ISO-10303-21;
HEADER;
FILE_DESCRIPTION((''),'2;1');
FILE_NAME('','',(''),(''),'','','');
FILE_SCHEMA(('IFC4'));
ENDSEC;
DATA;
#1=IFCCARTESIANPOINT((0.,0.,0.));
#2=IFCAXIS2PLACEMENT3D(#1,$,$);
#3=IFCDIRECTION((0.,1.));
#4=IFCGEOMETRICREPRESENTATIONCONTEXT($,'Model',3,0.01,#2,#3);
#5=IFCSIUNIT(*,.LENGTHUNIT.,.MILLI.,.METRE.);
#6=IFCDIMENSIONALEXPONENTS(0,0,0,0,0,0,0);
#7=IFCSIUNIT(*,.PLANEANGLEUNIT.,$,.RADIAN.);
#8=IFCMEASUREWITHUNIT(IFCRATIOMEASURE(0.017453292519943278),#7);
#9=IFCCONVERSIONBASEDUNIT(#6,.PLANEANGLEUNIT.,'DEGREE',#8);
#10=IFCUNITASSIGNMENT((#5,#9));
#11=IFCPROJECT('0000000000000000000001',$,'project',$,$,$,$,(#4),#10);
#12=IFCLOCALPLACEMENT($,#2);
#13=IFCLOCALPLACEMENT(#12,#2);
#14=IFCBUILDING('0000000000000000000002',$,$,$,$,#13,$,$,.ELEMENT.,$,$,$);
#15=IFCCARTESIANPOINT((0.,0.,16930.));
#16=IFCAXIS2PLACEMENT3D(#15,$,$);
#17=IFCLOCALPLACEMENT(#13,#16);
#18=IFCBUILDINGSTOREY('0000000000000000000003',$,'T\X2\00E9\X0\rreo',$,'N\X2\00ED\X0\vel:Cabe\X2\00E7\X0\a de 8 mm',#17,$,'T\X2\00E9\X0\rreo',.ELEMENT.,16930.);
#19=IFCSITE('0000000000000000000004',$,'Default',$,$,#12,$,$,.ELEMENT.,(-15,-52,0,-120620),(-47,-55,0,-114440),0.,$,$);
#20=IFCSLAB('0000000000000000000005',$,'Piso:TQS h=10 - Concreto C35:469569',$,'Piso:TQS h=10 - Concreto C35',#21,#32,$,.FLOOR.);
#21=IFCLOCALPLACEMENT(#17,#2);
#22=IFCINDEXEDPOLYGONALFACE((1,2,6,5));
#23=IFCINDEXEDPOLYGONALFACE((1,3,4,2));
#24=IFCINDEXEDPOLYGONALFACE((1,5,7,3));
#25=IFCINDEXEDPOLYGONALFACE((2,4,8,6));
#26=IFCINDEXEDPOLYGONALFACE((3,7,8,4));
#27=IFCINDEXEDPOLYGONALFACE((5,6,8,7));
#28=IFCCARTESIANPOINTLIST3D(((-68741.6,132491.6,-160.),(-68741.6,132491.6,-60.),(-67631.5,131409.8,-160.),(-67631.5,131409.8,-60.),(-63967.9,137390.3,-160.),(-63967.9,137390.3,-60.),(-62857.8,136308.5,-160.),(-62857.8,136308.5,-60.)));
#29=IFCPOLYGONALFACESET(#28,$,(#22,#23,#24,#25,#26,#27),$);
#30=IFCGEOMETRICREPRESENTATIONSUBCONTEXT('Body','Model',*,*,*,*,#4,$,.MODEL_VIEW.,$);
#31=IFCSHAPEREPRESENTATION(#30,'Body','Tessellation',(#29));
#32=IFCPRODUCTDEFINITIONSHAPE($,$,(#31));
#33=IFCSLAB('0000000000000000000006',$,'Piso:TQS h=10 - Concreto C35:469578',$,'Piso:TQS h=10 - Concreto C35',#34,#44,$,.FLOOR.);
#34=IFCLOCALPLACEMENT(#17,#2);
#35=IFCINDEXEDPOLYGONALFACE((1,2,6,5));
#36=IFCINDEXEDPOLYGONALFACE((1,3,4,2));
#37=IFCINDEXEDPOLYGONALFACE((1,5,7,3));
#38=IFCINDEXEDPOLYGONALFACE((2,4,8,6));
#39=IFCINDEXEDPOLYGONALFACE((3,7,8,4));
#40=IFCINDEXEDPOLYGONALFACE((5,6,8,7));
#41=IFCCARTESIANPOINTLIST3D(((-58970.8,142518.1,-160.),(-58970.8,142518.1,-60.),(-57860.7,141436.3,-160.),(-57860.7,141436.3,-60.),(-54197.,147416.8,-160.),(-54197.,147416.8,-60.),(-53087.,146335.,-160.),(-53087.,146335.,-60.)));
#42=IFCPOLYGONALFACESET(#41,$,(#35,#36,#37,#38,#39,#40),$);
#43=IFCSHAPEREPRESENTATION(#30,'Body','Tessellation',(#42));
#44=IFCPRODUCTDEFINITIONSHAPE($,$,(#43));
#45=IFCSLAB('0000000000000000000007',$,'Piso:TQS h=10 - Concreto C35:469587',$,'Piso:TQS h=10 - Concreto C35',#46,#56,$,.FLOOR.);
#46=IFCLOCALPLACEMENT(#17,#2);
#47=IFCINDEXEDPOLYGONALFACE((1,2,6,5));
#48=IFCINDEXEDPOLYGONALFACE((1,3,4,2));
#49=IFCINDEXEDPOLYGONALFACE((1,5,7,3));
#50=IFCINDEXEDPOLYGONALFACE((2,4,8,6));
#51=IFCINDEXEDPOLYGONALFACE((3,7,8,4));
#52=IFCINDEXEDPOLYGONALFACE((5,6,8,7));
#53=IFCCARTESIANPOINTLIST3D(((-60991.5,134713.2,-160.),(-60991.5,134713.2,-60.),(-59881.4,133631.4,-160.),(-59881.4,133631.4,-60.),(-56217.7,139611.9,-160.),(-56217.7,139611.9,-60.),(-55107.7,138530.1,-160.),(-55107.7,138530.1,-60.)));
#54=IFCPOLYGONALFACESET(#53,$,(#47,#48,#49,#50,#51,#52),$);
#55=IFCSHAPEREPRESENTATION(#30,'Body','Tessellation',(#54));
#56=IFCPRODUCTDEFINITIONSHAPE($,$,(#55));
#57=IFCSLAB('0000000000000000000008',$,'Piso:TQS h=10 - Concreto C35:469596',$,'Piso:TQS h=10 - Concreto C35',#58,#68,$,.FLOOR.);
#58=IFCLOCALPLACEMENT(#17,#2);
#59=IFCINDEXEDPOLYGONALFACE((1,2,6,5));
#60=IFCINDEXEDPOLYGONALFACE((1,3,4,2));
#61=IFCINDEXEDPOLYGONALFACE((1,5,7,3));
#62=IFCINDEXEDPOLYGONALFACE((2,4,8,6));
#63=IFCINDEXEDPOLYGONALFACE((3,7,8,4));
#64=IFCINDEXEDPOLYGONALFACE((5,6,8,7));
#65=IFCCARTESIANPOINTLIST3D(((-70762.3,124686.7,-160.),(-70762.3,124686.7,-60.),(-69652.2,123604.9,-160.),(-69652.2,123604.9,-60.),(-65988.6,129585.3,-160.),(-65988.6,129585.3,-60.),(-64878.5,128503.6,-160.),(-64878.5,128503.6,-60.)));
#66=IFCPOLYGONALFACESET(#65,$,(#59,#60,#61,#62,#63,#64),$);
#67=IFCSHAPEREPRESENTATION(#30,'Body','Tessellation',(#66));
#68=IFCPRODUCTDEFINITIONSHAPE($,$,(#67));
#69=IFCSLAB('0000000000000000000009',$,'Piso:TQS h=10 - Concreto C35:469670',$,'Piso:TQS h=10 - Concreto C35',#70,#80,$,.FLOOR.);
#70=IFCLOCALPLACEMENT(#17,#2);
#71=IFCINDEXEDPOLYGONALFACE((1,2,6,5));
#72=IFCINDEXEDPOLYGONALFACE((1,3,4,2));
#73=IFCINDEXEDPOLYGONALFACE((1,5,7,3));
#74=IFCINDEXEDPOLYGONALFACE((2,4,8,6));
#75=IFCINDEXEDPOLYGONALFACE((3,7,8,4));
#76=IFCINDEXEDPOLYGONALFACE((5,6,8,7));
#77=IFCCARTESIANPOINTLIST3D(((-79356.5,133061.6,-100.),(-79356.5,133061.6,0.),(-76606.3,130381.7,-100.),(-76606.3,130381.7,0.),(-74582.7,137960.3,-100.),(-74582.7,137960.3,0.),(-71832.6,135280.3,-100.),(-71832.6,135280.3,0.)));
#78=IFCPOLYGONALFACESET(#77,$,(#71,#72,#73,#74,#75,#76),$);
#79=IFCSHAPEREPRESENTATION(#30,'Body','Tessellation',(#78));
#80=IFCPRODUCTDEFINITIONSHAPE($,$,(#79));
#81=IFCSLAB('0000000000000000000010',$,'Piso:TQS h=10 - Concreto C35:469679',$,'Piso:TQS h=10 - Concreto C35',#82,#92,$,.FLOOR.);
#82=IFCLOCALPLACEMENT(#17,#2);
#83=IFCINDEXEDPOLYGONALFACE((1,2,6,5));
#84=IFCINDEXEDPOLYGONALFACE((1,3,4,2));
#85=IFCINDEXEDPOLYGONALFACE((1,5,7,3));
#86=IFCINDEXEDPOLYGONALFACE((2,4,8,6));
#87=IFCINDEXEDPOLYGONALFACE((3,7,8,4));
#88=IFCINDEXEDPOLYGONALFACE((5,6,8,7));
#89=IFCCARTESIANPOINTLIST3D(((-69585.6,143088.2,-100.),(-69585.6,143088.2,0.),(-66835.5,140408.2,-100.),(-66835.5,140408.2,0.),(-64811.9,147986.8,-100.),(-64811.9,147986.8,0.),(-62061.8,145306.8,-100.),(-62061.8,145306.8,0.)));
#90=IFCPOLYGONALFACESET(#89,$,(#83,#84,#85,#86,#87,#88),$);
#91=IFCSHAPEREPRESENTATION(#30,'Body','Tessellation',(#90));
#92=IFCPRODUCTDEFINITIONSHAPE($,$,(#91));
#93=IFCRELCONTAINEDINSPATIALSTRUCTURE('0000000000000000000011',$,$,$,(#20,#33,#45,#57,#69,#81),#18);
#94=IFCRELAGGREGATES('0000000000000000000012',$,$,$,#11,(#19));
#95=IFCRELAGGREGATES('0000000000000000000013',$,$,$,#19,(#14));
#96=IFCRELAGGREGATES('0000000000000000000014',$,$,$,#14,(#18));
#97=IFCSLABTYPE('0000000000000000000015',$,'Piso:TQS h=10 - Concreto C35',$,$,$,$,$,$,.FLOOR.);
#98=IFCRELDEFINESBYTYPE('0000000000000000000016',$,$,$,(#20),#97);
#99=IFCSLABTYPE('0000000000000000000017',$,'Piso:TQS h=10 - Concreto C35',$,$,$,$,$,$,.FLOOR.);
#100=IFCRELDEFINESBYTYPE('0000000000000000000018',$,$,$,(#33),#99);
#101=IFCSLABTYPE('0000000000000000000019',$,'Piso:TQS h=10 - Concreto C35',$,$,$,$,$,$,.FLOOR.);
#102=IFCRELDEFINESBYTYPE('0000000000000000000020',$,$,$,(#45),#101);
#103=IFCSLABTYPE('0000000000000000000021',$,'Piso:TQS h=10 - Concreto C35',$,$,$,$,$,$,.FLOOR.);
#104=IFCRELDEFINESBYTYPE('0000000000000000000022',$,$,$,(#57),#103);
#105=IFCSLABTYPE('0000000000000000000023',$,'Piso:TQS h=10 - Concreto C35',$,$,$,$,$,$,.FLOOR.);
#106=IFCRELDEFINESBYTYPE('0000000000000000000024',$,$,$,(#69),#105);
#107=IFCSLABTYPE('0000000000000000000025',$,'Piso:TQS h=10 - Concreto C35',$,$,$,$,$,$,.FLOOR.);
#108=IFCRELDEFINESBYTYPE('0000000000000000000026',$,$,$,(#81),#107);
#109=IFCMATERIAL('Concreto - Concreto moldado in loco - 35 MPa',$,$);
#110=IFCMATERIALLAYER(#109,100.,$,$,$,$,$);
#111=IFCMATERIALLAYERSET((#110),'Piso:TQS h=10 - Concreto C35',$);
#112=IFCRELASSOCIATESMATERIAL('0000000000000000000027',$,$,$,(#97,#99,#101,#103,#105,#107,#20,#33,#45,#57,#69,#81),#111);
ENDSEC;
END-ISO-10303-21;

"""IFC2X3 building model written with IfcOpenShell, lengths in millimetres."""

from ifc_helpers import new_model, entity, si_unit, converted_unit, direction, frame, frame_2d, origin, origin_2d_with_axis, place, context, subcontext, project, spatial, rectangle, extrude, material, layer, layer_set, layer_usage, type_object, element, save


model = new_model("IFC2X3")

# Units and contexts
model_context = context("Model", 3, precision=0.01, world=origin(), true_north=direction((0.0, 1.0)))
body_context = subcontext(model_context, "Body", "Model", "MODEL_VIEW")
ifc_project = project(units=[si_unit("LENGTHUNIT", "METRE", prefix="MILLI"), converted_unit("PLANEANGLEUNIT", "DEGREE", entity("IfcRatioMeasure", 0.017453292519943278), si_unit("PLANEANGLEUNIT", "RADIAN"), dimensions=[0, 0, 0, 0, 0, 0, 0])], contexts=[model_context])

# Site, building, storey
site_placement = place(None, origin())
site = spatial("IfcSite", under=ifc_project, at=site_placement, Name="Default", CompositionType="ELEMENT", RefLatitude=(-15, -52, 0, -120620), RefLongitude=(-47, -55, 0, -114440), RefElevation=0.0)
building_placement = place(site_placement, origin())
building = spatial("IfcBuilding", under=site, at=building_placement, CompositionType="ELEMENT")
storey_placement = place(building_placement, frame((0.0, 0.0, 16930.0)))
storey = spatial("IfcBuildingStorey", under=building, at=storey_placement, Name="Térreo", ObjectType="Nível:Cabeça de 8 mm", LongName="Térreo", CompositionType="ELEMENT", Elevation=16930.0)

# Shared definitions
ifc_material = material(Name="Concreto - Concreto moldado in loco - 35 MPa")

# Slabs
ifc_layer = layer(ifc_material, 100.0)
ifc_layer_set = layer_set([ifc_layer], Name="Piso:TQS h=10 - Concreto C35")
ifc_layer_usage_1 = layer_usage(ifc_layer_set, "AXIS3", "POSITIVE", 0.0)
slab_type_1 = type_object("IfcSlabType", Name="Piso:TQS h=10 - Concreto C35", PredefinedType="FLOOR", material=ifc_layer_set)
slab_1_placement = place(storey_placement, origin())
element("IfcSlab", 1, at=slab_1_placement, inside=storey, type_object=slab_type_1, material=ifc_layer_usage_1, Name="Piso:TQS h=10 - Concreto C35:469569", ObjectType="Piso:TQS h=10 - Concreto C35", PredefinedType="FLOOR", context=body_context, shape_type="SweptSolid", body=[
    extrude(rectangle(XDim=6840.0, YDim=1550.0, at=frame_2d((0.0, 0.0), x_axis=(1.0, 0.0))), frame((-65799.7, 134400.0, -60.0), z_axis=(0.0, 0.0, -1.0), x_axis=(-0.697915, -0.71618, 0.0)), (0.0, 0.0, 1.0), 100.0),
])
ifc_layer_usage_2 = layer_usage(ifc_layer_set, "AXIS3", "POSITIVE", 0.0)
slab_type_2 = type_object("IfcSlabType", Name="Piso:TQS h=10 - Concreto C35", PredefinedType="FLOOR", material=ifc_layer_set)
slab_2_placement = place(storey_placement, origin())
element("IfcSlab", 2, at=slab_2_placement, inside=storey, type_object=slab_type_2, material=ifc_layer_usage_2, Name="Piso:TQS h=10 - Concreto C35:469578", ObjectType="Piso:TQS h=10 - Concreto C35", PredefinedType="FLOOR", context=body_context, shape_type="SweptSolid", body=[
    extrude(rectangle(XDim=6840.0, YDim=1550.0, at=frame_2d((0.0, 0.0), x_axis=(1.0, 0.0))), frame((-56028.9, 144426.6, -60.0), z_axis=(0.0, 0.0, -1.0), x_axis=(-0.697915, -0.71618, 0.0)), (0.0, 0.0, 1.0), 100.0),
])
ifc_layer_usage_3 = layer_usage(ifc_layer_set, "AXIS3", "POSITIVE", 0.0)
slab_type_3 = type_object("IfcSlabType", Name="Piso:TQS h=10 - Concreto C35", PredefinedType="FLOOR", material=ifc_layer_set)
slab_3_placement = place(storey_placement, origin())
element("IfcSlab", 3, at=slab_3_placement, inside=storey, type_object=slab_type_3, material=ifc_layer_usage_3, Name="Piso:TQS h=10 - Concreto C35:469587", ObjectType="Piso:TQS h=10 - Concreto C35", PredefinedType="FLOOR", context=body_context, shape_type="SweptSolid", body=[
    extrude(rectangle(XDim=1550.0, YDim=6840.0, at=frame_2d((0.0, 0.0), x_axis=(1.0, 0.0))), frame((-58049.6, 136621.6, -60.0), z_axis=(0.0, 0.0, -1.0), x_axis=(0.71618, -0.697915, 0.0)), (0.0, 0.0, 1.0), 100.0),
])
ifc_layer_usage_4 = layer_usage(ifc_layer_set, "AXIS3", "POSITIVE", 0.0)
slab_type_4 = type_object("IfcSlabType", Name="Piso:TQS h=10 - Concreto C35", PredefinedType="FLOOR", material=ifc_layer_set)
slab_4_placement = place(storey_placement, origin())
element("IfcSlab", 4, at=slab_4_placement, inside=storey, type_object=slab_type_4, material=ifc_layer_usage_4, Name="Piso:TQS h=10 - Concreto C35:469596", ObjectType="Piso:TQS h=10 - Concreto C35", PredefinedType="FLOOR", context=body_context, shape_type="SweptSolid", body=[
    extrude(rectangle(XDim=6840.0, YDim=1550.0, at=frame_2d((0.0, 0.0), x_axis=(1.0, 0.0))), frame((-67820.4, 126595.1, -60.0), z_axis=(0.0, 0.0, -1.0), x_axis=(-0.697915, -0.71618, 0.0)), (0.0, 0.0, 1.0), 100.0),
])
ifc_layer_usage_5 = layer_usage(ifc_layer_set, "AXIS3", "POSITIVE", 0.0)
slab_type_5 = type_object("IfcSlabType", Name="Piso:TQS h=10 - Concreto C35", PredefinedType="FLOOR", material=ifc_layer_set)
slab_5_placement = place(storey_placement, origin())
element("IfcSlab", 5, at=slab_5_placement, inside=storey, type_object=slab_type_5, material=ifc_layer_usage_5, Name="Piso:TQS h=10 - Concreto C35:469670", ObjectType="Piso:TQS h=10 - Concreto C35", PredefinedType="FLOOR", context=body_context, shape_type="SweptSolid", body=[
    extrude(rectangle(XDim=3840.0, YDim=6840.0, at=frame_2d((0.0, 0.0), x_axis=(1.0, 0.0))), frame((-75594.5, 134171.0, 0.0), z_axis=(0.0, 0.0, -1.0), x_axis=(0.71618, -0.697915, 0.0)), (0.0, 0.0, 1.0), 100.0),
])
ifc_layer_usage_6 = layer_usage(ifc_layer_set, "AXIS3", "POSITIVE", 0.0)
slab_type_6 = type_object("IfcSlabType", Name="Piso:TQS h=10 - Concreto C35", PredefinedType="FLOOR", material=ifc_layer_set)
slab_6_placement = place(storey_placement, origin())
element("IfcSlab", 6, at=slab_6_placement, inside=storey, type_object=slab_type_6, material=ifc_layer_usage_6, Name="Piso:TQS h=10 - Concreto C35:469679", ObjectType="Piso:TQS h=10 - Concreto C35", PredefinedType="FLOOR", context=body_context, shape_type="SweptSolid", body=[
    extrude(rectangle(XDim=3840.0, YDim=6840.0, at=origin_2d_with_axis()), frame((-65823.7, 144197.5, 0.0), z_axis=(0.0, 0.0, -1.0), x_axis=(0.71618, -0.697915, 0.0)), (0.0, 0.0, 1.0), 100.0),
])

save(model, "model.ifc")
